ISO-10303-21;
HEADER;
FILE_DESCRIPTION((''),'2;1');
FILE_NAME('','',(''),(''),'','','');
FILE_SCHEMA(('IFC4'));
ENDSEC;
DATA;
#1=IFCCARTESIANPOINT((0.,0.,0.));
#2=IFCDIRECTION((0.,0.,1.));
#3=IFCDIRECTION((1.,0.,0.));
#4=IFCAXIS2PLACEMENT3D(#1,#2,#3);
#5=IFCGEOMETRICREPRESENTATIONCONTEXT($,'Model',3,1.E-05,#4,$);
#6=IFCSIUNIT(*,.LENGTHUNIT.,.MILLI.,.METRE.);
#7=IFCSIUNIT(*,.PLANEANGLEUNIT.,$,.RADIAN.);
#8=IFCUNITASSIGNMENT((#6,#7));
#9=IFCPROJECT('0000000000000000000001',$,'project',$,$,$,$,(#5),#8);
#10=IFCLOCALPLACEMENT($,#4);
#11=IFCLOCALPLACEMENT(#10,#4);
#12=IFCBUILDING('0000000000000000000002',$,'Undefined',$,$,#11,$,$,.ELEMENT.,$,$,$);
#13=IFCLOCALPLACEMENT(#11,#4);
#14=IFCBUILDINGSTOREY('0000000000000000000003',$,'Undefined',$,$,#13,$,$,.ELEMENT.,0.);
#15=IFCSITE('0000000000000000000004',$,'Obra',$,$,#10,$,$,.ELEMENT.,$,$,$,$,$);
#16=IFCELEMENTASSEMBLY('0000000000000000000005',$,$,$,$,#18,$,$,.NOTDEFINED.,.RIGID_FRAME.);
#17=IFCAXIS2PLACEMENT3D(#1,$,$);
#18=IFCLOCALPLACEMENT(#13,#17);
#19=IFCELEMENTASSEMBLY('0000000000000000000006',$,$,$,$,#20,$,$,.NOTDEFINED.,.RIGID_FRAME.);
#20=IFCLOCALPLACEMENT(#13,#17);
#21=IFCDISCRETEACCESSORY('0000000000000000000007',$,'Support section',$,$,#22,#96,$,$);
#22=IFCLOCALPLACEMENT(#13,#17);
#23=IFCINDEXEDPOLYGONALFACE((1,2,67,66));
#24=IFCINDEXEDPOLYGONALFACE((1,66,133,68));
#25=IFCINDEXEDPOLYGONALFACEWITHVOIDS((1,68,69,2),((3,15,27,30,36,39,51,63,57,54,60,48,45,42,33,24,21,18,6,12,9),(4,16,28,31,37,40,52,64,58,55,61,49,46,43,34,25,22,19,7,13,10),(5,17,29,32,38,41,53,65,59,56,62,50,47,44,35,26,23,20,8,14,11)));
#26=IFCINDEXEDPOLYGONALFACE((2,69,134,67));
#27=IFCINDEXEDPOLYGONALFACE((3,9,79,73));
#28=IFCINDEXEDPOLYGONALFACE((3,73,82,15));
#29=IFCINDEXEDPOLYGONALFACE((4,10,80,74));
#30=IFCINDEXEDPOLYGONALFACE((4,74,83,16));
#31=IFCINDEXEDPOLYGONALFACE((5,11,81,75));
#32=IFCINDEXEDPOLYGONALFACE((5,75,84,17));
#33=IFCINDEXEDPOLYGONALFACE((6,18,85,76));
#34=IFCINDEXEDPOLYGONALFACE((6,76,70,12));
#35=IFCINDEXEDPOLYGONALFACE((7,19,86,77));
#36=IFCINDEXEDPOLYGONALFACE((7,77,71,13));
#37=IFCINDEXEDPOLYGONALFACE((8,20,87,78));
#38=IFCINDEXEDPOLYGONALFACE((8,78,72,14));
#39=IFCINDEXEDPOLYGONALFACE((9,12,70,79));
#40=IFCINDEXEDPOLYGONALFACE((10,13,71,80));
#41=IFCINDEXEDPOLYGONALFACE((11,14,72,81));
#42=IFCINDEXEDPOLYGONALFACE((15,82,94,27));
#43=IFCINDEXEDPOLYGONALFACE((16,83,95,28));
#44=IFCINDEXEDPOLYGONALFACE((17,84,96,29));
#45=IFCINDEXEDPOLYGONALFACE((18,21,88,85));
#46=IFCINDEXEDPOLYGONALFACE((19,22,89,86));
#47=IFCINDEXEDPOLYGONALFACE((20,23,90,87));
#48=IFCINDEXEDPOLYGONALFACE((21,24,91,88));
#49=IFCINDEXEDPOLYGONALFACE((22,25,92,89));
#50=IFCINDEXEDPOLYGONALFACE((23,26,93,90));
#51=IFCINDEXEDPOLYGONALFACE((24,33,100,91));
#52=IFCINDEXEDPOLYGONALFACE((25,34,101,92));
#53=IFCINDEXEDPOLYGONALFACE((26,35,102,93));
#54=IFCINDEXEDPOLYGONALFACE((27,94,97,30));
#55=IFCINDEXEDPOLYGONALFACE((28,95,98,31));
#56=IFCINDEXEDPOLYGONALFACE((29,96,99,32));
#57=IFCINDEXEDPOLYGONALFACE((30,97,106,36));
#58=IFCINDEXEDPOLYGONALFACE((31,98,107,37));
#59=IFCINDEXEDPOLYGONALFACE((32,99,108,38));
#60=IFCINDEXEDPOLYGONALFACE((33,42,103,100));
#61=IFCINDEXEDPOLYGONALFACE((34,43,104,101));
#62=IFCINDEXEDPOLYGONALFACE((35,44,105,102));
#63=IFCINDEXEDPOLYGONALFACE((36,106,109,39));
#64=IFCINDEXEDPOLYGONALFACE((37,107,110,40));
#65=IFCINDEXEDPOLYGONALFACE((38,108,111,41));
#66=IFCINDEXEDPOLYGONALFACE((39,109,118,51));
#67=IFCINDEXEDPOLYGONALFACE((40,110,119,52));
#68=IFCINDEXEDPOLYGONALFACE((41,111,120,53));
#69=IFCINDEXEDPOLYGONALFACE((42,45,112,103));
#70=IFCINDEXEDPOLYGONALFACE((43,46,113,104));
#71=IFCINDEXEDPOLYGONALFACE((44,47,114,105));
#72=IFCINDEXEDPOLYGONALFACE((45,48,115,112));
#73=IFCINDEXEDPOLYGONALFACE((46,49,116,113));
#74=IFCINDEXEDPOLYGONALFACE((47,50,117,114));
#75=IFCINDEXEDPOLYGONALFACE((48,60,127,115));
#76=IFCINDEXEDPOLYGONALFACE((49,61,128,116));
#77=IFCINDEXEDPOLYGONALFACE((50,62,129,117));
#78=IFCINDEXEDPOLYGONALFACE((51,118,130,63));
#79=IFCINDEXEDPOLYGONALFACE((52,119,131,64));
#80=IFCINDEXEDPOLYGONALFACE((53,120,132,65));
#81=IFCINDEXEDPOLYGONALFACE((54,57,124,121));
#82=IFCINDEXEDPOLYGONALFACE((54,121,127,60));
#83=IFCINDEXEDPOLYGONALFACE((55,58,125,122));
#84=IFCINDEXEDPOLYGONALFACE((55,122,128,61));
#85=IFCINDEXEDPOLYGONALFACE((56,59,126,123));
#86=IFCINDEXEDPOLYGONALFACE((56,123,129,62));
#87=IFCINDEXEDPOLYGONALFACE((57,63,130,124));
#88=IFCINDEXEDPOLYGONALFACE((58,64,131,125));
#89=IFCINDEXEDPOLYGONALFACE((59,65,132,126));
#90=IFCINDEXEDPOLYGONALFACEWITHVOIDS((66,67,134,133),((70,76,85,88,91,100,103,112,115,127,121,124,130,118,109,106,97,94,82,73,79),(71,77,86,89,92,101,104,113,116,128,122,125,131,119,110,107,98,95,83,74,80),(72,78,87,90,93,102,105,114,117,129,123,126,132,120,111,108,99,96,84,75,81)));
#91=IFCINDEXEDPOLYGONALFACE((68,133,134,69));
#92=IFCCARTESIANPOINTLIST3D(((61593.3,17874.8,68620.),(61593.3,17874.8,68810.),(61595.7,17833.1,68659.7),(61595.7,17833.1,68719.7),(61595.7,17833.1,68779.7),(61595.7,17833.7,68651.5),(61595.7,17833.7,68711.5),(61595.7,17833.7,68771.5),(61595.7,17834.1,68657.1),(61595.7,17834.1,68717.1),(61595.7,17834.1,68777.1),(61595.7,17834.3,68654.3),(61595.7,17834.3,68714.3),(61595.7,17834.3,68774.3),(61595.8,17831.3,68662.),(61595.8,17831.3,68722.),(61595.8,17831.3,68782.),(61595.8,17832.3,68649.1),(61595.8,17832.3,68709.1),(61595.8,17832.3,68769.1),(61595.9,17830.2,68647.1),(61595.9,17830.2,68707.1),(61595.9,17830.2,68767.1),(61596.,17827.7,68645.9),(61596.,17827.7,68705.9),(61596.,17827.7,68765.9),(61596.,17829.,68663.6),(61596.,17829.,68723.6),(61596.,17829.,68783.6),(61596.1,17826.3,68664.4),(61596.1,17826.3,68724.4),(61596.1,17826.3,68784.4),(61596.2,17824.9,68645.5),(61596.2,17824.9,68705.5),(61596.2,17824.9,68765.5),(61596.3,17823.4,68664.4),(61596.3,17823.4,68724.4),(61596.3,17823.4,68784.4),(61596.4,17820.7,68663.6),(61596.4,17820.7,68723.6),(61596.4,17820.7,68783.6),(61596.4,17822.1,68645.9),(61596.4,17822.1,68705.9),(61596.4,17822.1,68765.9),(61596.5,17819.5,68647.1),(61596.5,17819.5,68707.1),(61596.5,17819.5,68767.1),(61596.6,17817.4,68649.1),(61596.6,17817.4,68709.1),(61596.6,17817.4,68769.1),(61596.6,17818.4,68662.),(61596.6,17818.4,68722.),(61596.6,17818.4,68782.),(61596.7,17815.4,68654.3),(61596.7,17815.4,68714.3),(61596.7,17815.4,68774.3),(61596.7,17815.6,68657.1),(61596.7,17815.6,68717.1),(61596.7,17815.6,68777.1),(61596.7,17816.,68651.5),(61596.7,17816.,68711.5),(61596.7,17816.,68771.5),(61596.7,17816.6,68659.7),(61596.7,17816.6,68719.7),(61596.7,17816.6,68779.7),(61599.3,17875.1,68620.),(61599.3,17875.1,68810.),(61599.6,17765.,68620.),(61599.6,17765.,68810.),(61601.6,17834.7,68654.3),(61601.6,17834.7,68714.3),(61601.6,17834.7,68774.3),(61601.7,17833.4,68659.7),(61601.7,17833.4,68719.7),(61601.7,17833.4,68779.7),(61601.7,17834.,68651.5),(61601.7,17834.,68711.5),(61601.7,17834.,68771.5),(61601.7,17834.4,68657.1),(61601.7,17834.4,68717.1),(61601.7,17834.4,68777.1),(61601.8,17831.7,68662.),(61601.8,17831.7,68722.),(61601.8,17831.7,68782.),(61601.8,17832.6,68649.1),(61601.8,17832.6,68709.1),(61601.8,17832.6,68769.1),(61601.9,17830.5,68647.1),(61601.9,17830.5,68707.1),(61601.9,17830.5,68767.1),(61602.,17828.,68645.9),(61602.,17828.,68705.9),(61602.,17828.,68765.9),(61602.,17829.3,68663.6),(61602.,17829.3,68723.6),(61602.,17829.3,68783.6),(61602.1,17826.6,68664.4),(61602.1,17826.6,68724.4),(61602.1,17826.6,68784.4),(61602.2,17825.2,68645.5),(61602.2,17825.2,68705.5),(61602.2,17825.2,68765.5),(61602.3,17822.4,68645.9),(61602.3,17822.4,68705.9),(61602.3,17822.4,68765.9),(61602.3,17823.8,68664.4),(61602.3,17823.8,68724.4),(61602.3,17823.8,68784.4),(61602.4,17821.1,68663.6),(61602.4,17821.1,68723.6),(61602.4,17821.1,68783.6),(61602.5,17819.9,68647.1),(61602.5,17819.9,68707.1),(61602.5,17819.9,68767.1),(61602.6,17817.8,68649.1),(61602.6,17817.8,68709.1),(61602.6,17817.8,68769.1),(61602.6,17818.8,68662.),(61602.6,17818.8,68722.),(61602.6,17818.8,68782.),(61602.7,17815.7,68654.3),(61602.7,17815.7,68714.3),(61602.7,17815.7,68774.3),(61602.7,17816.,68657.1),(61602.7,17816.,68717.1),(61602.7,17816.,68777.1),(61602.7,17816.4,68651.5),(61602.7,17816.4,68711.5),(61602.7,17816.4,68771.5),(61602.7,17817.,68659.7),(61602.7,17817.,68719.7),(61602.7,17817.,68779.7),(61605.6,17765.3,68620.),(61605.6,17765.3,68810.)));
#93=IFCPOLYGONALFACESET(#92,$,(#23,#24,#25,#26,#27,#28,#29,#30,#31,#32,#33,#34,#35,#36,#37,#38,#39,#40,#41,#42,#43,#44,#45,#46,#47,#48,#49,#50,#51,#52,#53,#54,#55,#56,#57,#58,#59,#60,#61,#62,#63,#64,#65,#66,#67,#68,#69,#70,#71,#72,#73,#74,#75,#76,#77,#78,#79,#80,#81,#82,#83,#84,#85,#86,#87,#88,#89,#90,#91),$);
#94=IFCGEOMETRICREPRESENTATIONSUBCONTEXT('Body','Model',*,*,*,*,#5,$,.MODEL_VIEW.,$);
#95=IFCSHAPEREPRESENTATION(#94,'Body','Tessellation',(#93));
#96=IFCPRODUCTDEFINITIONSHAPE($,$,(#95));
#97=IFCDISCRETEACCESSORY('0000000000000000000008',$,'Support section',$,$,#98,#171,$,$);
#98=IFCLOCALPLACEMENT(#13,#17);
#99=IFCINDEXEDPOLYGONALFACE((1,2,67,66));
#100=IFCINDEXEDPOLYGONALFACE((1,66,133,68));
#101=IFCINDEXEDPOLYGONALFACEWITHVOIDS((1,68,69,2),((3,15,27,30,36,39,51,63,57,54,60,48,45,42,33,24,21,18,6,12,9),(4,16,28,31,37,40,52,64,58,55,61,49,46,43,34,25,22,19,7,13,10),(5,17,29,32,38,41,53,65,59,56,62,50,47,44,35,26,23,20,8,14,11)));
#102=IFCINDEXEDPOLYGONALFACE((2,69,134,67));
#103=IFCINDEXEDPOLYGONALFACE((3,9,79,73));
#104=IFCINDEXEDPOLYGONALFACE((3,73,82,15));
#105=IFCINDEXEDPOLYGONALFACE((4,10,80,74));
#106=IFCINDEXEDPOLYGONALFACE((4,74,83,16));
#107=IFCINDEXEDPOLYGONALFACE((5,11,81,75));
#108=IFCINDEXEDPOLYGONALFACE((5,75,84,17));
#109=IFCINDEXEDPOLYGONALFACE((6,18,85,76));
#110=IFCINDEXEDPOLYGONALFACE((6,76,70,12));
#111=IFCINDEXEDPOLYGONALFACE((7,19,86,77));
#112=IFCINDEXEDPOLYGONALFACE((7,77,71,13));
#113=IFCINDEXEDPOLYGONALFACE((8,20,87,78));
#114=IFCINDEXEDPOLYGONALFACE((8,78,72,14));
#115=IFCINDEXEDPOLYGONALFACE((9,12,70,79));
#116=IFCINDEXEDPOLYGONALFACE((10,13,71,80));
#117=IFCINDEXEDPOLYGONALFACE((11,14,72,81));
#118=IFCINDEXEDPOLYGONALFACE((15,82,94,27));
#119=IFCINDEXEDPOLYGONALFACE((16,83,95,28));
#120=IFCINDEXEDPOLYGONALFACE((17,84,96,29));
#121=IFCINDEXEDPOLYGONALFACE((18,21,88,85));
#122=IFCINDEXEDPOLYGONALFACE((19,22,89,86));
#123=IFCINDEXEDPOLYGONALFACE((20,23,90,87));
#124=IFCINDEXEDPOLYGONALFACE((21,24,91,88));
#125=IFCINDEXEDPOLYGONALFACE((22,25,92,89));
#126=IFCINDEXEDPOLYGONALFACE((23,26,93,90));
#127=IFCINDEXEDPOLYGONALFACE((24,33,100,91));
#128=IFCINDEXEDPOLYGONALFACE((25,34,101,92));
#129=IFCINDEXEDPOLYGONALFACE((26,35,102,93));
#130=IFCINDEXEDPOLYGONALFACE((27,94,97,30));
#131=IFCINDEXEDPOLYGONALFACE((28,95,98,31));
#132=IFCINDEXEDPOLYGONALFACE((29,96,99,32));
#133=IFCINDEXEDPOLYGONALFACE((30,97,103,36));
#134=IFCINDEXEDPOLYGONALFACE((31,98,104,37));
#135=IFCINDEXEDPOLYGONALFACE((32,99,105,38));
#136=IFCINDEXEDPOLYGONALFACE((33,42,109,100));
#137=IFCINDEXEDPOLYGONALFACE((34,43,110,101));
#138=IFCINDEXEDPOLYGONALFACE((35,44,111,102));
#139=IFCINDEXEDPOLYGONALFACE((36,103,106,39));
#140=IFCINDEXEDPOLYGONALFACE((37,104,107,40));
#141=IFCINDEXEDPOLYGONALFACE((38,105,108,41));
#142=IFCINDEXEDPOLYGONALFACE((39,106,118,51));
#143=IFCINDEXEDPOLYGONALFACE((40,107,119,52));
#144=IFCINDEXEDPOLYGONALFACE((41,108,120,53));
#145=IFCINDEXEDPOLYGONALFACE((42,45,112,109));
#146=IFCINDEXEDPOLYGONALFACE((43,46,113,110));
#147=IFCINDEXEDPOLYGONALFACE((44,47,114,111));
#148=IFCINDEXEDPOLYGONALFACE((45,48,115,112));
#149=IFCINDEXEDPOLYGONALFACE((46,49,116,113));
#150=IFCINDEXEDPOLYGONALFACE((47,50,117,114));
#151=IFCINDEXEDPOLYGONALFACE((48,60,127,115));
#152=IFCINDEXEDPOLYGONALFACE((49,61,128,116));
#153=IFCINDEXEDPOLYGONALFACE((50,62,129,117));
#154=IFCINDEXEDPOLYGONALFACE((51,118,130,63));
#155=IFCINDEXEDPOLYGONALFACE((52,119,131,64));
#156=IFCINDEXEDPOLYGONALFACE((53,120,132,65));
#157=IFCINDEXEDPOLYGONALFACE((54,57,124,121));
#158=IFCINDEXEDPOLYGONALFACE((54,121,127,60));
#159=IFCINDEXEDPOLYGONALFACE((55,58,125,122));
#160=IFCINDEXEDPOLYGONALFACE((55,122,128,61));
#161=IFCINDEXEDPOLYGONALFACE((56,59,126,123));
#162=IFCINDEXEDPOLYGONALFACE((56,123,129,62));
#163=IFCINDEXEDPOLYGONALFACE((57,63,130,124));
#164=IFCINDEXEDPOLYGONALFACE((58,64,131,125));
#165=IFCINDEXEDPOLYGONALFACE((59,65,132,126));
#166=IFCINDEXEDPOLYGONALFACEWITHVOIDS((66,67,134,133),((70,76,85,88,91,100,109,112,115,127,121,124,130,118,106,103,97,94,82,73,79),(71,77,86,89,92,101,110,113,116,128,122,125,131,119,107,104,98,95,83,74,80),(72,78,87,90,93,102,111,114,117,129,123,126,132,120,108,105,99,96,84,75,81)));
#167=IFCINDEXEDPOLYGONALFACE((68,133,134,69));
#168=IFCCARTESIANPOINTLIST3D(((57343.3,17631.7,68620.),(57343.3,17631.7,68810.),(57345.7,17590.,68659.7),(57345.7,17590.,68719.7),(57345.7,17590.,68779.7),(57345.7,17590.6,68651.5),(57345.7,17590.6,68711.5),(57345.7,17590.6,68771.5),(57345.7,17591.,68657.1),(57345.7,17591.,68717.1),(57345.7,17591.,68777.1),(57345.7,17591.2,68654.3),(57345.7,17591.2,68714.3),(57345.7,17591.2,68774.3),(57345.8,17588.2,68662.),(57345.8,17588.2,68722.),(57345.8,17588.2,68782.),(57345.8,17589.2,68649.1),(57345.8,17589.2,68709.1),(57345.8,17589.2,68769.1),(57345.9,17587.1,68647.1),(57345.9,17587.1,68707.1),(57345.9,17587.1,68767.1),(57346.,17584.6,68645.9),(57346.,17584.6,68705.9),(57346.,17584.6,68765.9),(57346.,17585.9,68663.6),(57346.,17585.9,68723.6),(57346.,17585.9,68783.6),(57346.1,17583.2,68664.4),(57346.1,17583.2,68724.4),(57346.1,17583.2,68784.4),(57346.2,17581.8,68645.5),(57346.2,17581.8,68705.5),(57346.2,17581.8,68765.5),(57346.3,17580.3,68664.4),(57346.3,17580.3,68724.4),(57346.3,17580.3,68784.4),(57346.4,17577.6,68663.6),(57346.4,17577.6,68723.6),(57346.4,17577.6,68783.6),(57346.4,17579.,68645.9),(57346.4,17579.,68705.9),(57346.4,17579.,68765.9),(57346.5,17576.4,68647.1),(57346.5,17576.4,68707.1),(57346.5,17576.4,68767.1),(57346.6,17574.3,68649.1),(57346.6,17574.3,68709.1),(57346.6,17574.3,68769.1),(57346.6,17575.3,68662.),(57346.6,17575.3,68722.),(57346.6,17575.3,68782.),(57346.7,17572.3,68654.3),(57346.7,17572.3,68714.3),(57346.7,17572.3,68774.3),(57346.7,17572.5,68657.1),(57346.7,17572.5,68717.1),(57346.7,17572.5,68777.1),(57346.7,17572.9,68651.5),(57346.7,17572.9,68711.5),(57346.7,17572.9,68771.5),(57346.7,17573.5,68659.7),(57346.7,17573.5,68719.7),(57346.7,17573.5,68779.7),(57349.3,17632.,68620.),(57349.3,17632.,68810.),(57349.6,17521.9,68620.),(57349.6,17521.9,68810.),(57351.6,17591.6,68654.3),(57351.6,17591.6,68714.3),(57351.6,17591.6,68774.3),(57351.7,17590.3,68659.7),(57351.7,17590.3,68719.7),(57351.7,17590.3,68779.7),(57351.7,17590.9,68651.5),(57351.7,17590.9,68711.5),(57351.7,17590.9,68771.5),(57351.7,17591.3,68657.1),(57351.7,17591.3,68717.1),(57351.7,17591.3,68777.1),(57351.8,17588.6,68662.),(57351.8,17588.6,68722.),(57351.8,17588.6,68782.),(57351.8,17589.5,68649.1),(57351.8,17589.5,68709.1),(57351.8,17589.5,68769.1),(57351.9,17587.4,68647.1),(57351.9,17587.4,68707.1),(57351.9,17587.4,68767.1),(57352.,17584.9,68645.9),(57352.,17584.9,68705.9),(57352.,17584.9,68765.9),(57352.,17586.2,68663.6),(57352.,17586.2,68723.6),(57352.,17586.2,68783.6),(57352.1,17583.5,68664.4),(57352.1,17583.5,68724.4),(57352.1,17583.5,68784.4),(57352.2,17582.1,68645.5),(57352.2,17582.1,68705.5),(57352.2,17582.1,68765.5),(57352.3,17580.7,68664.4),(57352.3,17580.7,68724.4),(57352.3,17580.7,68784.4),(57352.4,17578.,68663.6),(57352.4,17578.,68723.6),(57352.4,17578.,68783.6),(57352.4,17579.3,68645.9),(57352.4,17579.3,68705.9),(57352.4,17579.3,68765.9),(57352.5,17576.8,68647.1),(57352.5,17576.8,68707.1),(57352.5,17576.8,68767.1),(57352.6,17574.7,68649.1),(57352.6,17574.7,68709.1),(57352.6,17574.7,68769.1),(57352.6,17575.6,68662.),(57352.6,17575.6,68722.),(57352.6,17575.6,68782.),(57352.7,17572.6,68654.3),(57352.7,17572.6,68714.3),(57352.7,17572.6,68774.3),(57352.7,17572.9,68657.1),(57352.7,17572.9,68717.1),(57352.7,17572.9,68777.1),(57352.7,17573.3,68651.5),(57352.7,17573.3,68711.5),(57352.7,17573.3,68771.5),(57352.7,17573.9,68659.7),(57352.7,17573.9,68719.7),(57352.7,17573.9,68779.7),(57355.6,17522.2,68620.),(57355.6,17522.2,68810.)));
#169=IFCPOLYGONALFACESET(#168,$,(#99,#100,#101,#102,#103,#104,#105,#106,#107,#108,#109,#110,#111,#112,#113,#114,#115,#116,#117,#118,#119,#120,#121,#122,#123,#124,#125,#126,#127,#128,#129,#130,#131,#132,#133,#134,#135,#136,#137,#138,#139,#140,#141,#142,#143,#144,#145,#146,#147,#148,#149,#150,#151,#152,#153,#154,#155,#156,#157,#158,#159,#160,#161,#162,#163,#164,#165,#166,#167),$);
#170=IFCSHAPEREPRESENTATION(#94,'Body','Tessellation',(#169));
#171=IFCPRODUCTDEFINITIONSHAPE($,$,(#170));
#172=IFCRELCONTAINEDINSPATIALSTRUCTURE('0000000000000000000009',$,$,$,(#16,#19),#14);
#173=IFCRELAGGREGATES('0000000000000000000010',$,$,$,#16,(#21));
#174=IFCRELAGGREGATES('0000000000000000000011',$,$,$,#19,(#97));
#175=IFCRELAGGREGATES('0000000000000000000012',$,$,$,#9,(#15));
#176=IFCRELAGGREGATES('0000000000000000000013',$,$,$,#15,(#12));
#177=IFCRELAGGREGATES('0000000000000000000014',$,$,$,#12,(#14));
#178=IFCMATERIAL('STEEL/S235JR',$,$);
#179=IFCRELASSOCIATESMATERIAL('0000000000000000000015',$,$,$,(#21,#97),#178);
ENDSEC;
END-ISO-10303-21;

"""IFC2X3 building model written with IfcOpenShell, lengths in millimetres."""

from ifc_helpers import new_model, si_unit, frame, origin_with_axes, origin_2d_with_axis, place, context, subcontext, project, spatial, rectangle, circle, extrude, source, transform, mapped, material, element, aggregate, save


model = new_model("IFC2X3")

# Units and contexts
model_context = context("Model", 3, precision=1e-05, world=origin_with_axes())
body_context = subcontext(model_context, "Body", "Model", "MODEL_VIEW")
ifc_project = project(units=[si_unit("LENGTHUNIT", "METRE", prefix="MILLI"), si_unit("PLANEANGLEUNIT", "RADIAN")], contexts=[model_context])

# Site, building, storey
site_placement = place(None, origin_with_axes())
site = spatial("IfcSite", under=ifc_project, at=site_placement, Name="Obra", CompositionType="ELEMENT")
building_placement = place(site_placement, origin_with_axes())
building = spatial("IfcBuilding", under=site, at=building_placement, Name="Undefined", CompositionType="ELEMENT")
storey_placement = place(building_placement, origin_with_axes())
storey = spatial("IfcBuildingStorey", under=building, at=storey_placement, Name="Undefined", CompositionType="ELEMENT", Elevation=0.0)

# Element assemblies
ifc_material_1 = material(Name="STEEL/S235JR")
assembly_1_placement = place(storey_placement, origin_with_axes())
assembly_1 = element("IfcElementAssembly", 1, at=assembly_1_placement, inside=storey, AssemblyPlace="NOTDEFINED", PredefinedType="RIGID_FRAME")
assembly_2_placement = place(storey_placement, origin_with_axes())
assembly_2 = element("IfcElementAssembly", 2, at=assembly_2_placement, inside=storey, AssemblyPlace="NOTDEFINED", PredefinedType="RIGID_FRAME")

# Discrete accessories, openings
discrete_accessory_1_placement = place(assembly_1_placement, frame((61599.5, 17820.0, 68620.0), z_axis=(0.0, 0.0, 1.0), x_axis=(0.057107, -0.998368, 0.0)))
discrete_accessory_1 = element("IfcDiscreteAccessory", 3, at=discrete_accessory_1_placement, material=ifc_material_1, Name="Support section", context=body_context, shape_type="SweptSolid", body=[
    extrude(rectangle(XDim=6.0, YDim=110.0, at=origin_2d_with_axis()), frame((0.0, 0.0, 190.0), z_axis=(0.0, 0.0, -1.0), x_axis=(0.0, 1.0, 0.0)), (0.0, 0.0, 1.0), 190.0),
])
shared_shape_1 = source(origin_with_axes(), body_context, "Body", "SweptSolid", [
    extrude(circle(Radius=9.5, at=origin_2d_with_axis()), frame((0.0, -9.2, 0.0), z_axis=(0.0, 1.0, 0.0), x_axis=(1.0, 0.0, 0.0)), (0.0, 0.0, 1.0), 6.2),
])
opening_1_placement = place(assembly_1_placement, frame((61596.0, 17774.8, 68835.0), z_axis=(-0.057107, 0.998368, 0.0), x_axis=(0.0, 0.0, -1.0)))
element("IfcOpeningElement", 4, at=opening_1_placement, cuts=discrete_accessory_1, ObjectType="Opening", context=body_context, shape_type="MappedRepresentation", body=[
    mapped(shared_shape_1, transform((60.0, 0.0, 50.0))),
    mapped(shared_shape_1, transform((120.0, 0.0, 50.0))),
    mapped(shared_shape_1, transform((180.0, 0.0, 50.0))),
])
aggregate(assembly_1, [discrete_accessory_1])
discrete_accessory_2_placement = place(assembly_2_placement, frame((57349.5, 17576.9, 68620.0), z_axis=(0.0, 0.0, 1.0), x_axis=(0.057107, -0.998368, 0.0)))
discrete_accessory_2 = element("IfcDiscreteAccessory", 5, at=discrete_accessory_2_placement, material=ifc_material_1, Name="Support section", context=body_context, shape_type="SweptSolid", body=[
    extrude(rectangle(XDim=6.0, YDim=110.0, at=origin_2d_with_axis()), frame((0.0, 0.0, 190.0), z_axis=(0.0, 0.0, -1.0), x_axis=(0.0, 1.0, 0.0)), (0.0, 0.0, 1.0), 190.0),
])
opening_2_placement = place(assembly_2_placement, frame((57346.0, 17531.7, 68835.0), z_axis=(-0.057107, 0.998368, 0.0), x_axis=(0.0, 0.0, -1.0)))
element("IfcOpeningElement", 6, at=opening_2_placement, cuts=discrete_accessory_2, ObjectType="Opening", context=body_context, shape_type="MappedRepresentation", body=[
    mapped(shared_shape_1, transform((60.0, 0.0, 50.0))),
    mapped(shared_shape_1, transform((120.0, 0.0, 50.0))),
    mapped(shared_shape_1, transform((180.0, 0.0, 50.0))),
])
aggregate(assembly_2, [discrete_accessory_2])

save(model, "model.ifc")
